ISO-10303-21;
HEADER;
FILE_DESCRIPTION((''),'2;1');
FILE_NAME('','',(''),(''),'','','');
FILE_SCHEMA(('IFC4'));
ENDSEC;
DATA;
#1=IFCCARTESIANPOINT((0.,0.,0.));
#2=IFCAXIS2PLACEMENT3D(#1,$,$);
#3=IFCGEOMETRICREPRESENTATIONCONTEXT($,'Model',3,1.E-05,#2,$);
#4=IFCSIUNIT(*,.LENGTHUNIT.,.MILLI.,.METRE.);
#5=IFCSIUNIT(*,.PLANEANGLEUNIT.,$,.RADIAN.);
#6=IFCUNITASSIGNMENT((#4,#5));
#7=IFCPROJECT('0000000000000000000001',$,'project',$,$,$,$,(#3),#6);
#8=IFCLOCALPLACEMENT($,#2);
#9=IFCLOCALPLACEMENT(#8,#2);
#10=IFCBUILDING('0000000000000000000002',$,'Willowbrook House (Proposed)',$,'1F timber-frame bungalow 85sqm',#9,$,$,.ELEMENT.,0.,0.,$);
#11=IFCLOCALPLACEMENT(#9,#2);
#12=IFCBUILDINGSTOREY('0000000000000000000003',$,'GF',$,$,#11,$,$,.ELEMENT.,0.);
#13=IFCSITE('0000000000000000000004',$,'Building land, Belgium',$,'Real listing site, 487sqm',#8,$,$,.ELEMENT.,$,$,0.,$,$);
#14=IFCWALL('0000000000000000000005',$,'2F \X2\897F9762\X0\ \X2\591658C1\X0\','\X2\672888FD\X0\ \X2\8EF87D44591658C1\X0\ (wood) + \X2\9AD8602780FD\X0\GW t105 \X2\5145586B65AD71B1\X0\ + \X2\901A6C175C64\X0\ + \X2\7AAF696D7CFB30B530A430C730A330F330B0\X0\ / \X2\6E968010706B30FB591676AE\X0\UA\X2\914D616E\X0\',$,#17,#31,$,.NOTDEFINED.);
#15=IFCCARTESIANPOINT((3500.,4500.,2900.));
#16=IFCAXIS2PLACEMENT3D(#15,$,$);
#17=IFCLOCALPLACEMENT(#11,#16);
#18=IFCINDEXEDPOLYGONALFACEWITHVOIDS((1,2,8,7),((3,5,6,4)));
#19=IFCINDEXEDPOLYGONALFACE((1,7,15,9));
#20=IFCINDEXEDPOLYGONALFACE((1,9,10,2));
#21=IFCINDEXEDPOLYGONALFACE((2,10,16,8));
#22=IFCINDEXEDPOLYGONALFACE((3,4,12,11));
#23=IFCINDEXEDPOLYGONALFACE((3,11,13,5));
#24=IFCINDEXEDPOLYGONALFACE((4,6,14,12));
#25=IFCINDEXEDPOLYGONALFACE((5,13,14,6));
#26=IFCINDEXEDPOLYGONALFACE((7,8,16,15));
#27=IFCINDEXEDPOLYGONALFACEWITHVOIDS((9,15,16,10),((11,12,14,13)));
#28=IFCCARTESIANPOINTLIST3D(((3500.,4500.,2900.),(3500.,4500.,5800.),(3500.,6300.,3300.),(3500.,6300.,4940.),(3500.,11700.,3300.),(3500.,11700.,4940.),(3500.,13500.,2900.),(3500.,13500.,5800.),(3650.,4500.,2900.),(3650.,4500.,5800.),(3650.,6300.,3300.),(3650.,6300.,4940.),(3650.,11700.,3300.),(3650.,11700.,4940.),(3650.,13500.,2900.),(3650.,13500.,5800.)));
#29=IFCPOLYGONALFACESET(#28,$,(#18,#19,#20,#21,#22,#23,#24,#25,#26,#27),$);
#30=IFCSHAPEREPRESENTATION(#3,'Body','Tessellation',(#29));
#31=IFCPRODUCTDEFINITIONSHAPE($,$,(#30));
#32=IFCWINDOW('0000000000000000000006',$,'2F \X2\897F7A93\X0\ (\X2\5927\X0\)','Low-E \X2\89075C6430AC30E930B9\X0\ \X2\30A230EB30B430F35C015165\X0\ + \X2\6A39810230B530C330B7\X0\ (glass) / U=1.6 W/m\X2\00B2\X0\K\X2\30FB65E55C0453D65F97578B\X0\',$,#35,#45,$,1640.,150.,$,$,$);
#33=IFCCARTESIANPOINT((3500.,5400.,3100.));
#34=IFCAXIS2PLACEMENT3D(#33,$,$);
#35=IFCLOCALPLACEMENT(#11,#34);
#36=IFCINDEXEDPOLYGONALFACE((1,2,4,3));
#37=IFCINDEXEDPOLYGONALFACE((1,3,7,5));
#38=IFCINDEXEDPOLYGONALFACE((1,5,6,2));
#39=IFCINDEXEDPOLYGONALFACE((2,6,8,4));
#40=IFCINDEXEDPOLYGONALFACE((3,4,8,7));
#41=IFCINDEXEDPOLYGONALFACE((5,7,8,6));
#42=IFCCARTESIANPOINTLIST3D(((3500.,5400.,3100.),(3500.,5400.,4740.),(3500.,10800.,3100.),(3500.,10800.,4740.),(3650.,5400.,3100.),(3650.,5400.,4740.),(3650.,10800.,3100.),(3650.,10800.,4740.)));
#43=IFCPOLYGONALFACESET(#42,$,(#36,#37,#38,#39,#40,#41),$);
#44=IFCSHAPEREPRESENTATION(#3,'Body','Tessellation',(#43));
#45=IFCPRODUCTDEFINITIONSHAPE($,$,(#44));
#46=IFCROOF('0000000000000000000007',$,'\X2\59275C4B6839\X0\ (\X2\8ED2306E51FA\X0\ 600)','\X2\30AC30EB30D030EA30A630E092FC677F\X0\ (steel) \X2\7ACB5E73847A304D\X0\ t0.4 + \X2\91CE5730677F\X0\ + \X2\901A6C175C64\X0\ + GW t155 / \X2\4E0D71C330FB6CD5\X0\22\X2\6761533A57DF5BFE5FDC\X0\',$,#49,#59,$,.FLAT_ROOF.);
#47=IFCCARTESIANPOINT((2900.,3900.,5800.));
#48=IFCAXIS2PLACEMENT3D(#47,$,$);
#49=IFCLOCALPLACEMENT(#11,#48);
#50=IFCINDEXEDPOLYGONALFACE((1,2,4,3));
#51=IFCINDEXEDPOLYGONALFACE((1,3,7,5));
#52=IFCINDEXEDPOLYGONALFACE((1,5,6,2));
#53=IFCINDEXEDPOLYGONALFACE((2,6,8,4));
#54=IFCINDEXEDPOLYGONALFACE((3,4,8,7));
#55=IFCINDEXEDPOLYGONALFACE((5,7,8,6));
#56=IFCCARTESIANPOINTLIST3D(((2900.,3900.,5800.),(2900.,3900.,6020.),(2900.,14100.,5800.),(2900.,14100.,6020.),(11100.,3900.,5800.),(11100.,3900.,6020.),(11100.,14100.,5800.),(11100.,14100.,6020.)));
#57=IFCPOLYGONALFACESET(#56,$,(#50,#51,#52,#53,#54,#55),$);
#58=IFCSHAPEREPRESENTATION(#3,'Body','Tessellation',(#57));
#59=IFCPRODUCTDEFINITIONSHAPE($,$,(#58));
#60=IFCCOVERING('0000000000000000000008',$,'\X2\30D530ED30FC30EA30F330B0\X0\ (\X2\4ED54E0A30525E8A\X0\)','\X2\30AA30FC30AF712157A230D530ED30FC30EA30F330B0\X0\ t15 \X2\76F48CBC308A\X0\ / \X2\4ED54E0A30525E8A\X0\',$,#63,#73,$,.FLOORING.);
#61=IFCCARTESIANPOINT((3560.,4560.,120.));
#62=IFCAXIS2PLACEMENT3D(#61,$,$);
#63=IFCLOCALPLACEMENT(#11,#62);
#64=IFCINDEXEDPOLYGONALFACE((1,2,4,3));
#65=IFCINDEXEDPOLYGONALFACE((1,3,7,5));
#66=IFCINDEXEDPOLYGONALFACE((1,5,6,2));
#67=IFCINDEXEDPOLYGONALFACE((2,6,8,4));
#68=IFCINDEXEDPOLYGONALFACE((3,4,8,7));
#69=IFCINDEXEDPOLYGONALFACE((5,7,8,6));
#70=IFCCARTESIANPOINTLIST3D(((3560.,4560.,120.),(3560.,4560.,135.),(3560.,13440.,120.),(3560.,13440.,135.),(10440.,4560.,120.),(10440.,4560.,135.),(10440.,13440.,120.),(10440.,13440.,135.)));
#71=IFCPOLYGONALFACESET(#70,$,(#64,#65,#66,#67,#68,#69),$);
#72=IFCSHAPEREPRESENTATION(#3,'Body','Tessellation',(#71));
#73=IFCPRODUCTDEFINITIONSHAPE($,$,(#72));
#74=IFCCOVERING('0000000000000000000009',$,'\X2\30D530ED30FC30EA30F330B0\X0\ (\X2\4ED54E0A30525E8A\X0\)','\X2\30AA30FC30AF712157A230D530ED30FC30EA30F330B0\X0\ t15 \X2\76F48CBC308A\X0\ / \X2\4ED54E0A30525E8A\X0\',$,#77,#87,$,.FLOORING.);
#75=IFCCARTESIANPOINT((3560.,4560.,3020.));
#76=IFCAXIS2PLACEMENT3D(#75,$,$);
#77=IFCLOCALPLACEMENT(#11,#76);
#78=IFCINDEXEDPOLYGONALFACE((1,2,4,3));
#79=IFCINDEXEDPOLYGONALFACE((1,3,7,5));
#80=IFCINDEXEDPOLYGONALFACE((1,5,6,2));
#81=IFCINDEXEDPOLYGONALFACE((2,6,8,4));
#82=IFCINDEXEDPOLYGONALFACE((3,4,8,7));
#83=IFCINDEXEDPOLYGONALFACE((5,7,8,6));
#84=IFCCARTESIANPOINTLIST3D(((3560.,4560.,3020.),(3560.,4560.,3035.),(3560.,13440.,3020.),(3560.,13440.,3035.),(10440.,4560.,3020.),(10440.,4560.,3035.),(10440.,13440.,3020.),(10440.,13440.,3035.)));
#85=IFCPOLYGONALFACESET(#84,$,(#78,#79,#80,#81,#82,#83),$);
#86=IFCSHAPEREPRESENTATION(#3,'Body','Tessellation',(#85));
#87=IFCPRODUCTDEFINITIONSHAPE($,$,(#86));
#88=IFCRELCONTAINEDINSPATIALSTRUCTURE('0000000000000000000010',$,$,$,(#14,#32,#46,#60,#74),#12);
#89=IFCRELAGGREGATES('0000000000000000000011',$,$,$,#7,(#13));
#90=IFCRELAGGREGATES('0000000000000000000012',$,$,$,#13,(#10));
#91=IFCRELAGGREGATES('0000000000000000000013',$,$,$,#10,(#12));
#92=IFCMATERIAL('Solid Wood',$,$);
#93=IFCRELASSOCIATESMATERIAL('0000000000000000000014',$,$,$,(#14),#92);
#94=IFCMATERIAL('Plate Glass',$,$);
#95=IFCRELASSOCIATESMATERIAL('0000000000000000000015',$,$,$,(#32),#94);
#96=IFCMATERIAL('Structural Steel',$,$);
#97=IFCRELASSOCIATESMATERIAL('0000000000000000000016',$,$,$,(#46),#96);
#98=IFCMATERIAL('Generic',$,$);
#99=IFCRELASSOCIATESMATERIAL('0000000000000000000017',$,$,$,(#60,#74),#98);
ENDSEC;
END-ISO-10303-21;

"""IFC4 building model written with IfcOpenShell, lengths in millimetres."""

from ifc_helpers import new_model, si_unit, frame, frame_2d, origin, place, context, project, spatial, rectangle, extrude, material, element, fill, save


model = new_model("IFC4")

# Units and contexts
model_context = context("Model", 3, precision=1e-05, world=origin())
ifc_project = project(units=[si_unit("LENGTHUNIT", "METRE", prefix="MILLI"), si_unit("PLANEANGLEUNIT", "RADIAN")], contexts=[model_context])

# Site, building, storey
site_placement = place(None, origin())
site = spatial("IfcSite", under=ifc_project, at=site_placement, Name="Building land, Belgium", ObjectType="Real listing site, 487sqm", CompositionType="ELEMENT", RefElevation=0.0)
building_placement = place(site_placement, origin())
building = spatial("IfcBuilding", under=site, at=building_placement, Name="Willowbrook House (Proposed)", ObjectType="1F timber-frame bungalow 85sqm", CompositionType="ELEMENT", ElevationOfRefHeight=0.0, ElevationOfTerrain=0.0)
storey_placement = place(building_placement, origin())
storey = spatial("IfcBuildingStorey", under=building, at=storey_placement, Name="GF", CompositionType="ELEMENT", Elevation=0.0)

# Shared definitions
ifc_material_1 = material(Name="Solid Wood")
ifc_material_2 = material(Name="Generic")

# Shared definitions
ifc_material_3 = material(Name="Plate Glass")

# Wall, opening, window
wall_1_placement = place(storey_placement, frame((3500.0, 4500.0, 2900.0)))
wall_1 = element("IfcWall", 1, at=wall_1_placement, inside=storey, material=ifc_material_1, Name="2F 西面 外壁", Description="木製 軸組外壁 (wood) + 高性能GW t105 充填断熱 + 通気層 + 窯業系サイディング / 準耐火・外皮UA配慮", PredefinedType="NOTDEFINED", context=model_context, shape_type="SweptSolid", body=[
    extrude(rectangle(XDim=150.0, YDim=9000.0, at=frame_2d((75.0, 4500.0))), frame((3500.0, 4500.0, 2900.0)), (0.0, 0.0, 1.0), 2900.0),
])
opening_1_placement = place(storey_placement, frame((3500.0, 5400.0, 3100.0)))
opening_1 = element("IfcOpeningElement", 2, at=opening_1_placement, cuts=wall_1, PredefinedType="NOTDEFINED", context=model_context, shape_type="SweptSolid", body=[
    extrude(rectangle(XDim=150.0, YDim=5400.0, at=frame_2d((75.0, 2700.0))), frame((3500.0, 5400.0, 3100.0)), (0.0, 0.0, 1.0), 1640.0),
])
window_1_placement = place(storey_placement, frame((3500.0, 5400.0, 3100.0)))
window_1 = element("IfcWindow", 3, at=window_1_placement, inside=storey, material=ifc_material_3, Name="2F 西窓 (大)", Description="Low-E 複層ガラス アルゴン封入 + 樹脂サッシ (glass) / U=1.6 W/m²K・日射取得型", OverallHeight=1640.0, OverallWidth=150.0, context=model_context, shape_type="SweptSolid", body=[
    extrude(rectangle(XDim=150.0, YDim=5400.0, at=frame_2d((75.0, 2700.0))), frame((3500.0, 5400.0, 3100.0)), (0.0, 0.0, 1.0), 1640.0),
])
fill(opening_1, window_1)

# Roof
ifc_material_4 = material(Name="Structural Steel")
roof_placement = place(storey_placement, frame((2900.0, 3900.0, 5800.0)))
element("IfcRoof", 4, at=roof_placement, inside=storey, material=ifc_material_4, Name="大屋根 (軒の出 600)", Description="ガルバリウム鋼板 (steel) 立平葺き t0.4 + 野地板 + 通気層 + GW t155 / 不燃・法22条区域対応", PredefinedType="FLAT_ROOF", context=model_context, shape_type="SweptSolid", body=[
    extrude(rectangle(XDim=8200.0, YDim=10200.0, at=frame_2d((4100.0, 5100.0))), frame((2900.0, 3900.0, 5800.0)), (0.0, 0.0, 1.0), 220.0),
])

# Coverings
covering_1_placement = place(storey_placement, frame((3560.0, 4560.0, 120.0)))
element("IfcCovering", 5, at=covering_1_placement, inside=storey, material=ifc_material_2, Name="フローリング (仕上げ床)", Description="オーク無垢フローリング t15 直貼り / 仕上げ床", PredefinedType="FLOORING", context=model_context, shape_type="SweptSolid", body=[
    extrude(rectangle(XDim=6880.0, YDim=8880.0, at=frame_2d((3440.0, 4440.0))), frame((3560.0, 4560.0, 120.0)), (0.0, 0.0, 1.0), 15.0),
])
covering_2_placement = place(storey_placement, frame((3560.0, 4560.0, 3020.0)))
element("IfcCovering", 6, at=covering_2_placement, inside=storey, material=ifc_material_2, Name="フローリング (仕上げ床)", Description="オーク無垢フローリング t15 直貼り / 仕上げ床", PredefinedType="FLOORING", context=model_context, shape_type="SweptSolid", body=[
    extrude(rectangle(XDim=6880.0, YDim=8880.0, at=frame_2d((3440.0, 4440.0))), frame((3560.0, 4560.0, 3020.0)), (0.0, 0.0, 1.0), 15.0),
])

save(model, "model.ifc")
